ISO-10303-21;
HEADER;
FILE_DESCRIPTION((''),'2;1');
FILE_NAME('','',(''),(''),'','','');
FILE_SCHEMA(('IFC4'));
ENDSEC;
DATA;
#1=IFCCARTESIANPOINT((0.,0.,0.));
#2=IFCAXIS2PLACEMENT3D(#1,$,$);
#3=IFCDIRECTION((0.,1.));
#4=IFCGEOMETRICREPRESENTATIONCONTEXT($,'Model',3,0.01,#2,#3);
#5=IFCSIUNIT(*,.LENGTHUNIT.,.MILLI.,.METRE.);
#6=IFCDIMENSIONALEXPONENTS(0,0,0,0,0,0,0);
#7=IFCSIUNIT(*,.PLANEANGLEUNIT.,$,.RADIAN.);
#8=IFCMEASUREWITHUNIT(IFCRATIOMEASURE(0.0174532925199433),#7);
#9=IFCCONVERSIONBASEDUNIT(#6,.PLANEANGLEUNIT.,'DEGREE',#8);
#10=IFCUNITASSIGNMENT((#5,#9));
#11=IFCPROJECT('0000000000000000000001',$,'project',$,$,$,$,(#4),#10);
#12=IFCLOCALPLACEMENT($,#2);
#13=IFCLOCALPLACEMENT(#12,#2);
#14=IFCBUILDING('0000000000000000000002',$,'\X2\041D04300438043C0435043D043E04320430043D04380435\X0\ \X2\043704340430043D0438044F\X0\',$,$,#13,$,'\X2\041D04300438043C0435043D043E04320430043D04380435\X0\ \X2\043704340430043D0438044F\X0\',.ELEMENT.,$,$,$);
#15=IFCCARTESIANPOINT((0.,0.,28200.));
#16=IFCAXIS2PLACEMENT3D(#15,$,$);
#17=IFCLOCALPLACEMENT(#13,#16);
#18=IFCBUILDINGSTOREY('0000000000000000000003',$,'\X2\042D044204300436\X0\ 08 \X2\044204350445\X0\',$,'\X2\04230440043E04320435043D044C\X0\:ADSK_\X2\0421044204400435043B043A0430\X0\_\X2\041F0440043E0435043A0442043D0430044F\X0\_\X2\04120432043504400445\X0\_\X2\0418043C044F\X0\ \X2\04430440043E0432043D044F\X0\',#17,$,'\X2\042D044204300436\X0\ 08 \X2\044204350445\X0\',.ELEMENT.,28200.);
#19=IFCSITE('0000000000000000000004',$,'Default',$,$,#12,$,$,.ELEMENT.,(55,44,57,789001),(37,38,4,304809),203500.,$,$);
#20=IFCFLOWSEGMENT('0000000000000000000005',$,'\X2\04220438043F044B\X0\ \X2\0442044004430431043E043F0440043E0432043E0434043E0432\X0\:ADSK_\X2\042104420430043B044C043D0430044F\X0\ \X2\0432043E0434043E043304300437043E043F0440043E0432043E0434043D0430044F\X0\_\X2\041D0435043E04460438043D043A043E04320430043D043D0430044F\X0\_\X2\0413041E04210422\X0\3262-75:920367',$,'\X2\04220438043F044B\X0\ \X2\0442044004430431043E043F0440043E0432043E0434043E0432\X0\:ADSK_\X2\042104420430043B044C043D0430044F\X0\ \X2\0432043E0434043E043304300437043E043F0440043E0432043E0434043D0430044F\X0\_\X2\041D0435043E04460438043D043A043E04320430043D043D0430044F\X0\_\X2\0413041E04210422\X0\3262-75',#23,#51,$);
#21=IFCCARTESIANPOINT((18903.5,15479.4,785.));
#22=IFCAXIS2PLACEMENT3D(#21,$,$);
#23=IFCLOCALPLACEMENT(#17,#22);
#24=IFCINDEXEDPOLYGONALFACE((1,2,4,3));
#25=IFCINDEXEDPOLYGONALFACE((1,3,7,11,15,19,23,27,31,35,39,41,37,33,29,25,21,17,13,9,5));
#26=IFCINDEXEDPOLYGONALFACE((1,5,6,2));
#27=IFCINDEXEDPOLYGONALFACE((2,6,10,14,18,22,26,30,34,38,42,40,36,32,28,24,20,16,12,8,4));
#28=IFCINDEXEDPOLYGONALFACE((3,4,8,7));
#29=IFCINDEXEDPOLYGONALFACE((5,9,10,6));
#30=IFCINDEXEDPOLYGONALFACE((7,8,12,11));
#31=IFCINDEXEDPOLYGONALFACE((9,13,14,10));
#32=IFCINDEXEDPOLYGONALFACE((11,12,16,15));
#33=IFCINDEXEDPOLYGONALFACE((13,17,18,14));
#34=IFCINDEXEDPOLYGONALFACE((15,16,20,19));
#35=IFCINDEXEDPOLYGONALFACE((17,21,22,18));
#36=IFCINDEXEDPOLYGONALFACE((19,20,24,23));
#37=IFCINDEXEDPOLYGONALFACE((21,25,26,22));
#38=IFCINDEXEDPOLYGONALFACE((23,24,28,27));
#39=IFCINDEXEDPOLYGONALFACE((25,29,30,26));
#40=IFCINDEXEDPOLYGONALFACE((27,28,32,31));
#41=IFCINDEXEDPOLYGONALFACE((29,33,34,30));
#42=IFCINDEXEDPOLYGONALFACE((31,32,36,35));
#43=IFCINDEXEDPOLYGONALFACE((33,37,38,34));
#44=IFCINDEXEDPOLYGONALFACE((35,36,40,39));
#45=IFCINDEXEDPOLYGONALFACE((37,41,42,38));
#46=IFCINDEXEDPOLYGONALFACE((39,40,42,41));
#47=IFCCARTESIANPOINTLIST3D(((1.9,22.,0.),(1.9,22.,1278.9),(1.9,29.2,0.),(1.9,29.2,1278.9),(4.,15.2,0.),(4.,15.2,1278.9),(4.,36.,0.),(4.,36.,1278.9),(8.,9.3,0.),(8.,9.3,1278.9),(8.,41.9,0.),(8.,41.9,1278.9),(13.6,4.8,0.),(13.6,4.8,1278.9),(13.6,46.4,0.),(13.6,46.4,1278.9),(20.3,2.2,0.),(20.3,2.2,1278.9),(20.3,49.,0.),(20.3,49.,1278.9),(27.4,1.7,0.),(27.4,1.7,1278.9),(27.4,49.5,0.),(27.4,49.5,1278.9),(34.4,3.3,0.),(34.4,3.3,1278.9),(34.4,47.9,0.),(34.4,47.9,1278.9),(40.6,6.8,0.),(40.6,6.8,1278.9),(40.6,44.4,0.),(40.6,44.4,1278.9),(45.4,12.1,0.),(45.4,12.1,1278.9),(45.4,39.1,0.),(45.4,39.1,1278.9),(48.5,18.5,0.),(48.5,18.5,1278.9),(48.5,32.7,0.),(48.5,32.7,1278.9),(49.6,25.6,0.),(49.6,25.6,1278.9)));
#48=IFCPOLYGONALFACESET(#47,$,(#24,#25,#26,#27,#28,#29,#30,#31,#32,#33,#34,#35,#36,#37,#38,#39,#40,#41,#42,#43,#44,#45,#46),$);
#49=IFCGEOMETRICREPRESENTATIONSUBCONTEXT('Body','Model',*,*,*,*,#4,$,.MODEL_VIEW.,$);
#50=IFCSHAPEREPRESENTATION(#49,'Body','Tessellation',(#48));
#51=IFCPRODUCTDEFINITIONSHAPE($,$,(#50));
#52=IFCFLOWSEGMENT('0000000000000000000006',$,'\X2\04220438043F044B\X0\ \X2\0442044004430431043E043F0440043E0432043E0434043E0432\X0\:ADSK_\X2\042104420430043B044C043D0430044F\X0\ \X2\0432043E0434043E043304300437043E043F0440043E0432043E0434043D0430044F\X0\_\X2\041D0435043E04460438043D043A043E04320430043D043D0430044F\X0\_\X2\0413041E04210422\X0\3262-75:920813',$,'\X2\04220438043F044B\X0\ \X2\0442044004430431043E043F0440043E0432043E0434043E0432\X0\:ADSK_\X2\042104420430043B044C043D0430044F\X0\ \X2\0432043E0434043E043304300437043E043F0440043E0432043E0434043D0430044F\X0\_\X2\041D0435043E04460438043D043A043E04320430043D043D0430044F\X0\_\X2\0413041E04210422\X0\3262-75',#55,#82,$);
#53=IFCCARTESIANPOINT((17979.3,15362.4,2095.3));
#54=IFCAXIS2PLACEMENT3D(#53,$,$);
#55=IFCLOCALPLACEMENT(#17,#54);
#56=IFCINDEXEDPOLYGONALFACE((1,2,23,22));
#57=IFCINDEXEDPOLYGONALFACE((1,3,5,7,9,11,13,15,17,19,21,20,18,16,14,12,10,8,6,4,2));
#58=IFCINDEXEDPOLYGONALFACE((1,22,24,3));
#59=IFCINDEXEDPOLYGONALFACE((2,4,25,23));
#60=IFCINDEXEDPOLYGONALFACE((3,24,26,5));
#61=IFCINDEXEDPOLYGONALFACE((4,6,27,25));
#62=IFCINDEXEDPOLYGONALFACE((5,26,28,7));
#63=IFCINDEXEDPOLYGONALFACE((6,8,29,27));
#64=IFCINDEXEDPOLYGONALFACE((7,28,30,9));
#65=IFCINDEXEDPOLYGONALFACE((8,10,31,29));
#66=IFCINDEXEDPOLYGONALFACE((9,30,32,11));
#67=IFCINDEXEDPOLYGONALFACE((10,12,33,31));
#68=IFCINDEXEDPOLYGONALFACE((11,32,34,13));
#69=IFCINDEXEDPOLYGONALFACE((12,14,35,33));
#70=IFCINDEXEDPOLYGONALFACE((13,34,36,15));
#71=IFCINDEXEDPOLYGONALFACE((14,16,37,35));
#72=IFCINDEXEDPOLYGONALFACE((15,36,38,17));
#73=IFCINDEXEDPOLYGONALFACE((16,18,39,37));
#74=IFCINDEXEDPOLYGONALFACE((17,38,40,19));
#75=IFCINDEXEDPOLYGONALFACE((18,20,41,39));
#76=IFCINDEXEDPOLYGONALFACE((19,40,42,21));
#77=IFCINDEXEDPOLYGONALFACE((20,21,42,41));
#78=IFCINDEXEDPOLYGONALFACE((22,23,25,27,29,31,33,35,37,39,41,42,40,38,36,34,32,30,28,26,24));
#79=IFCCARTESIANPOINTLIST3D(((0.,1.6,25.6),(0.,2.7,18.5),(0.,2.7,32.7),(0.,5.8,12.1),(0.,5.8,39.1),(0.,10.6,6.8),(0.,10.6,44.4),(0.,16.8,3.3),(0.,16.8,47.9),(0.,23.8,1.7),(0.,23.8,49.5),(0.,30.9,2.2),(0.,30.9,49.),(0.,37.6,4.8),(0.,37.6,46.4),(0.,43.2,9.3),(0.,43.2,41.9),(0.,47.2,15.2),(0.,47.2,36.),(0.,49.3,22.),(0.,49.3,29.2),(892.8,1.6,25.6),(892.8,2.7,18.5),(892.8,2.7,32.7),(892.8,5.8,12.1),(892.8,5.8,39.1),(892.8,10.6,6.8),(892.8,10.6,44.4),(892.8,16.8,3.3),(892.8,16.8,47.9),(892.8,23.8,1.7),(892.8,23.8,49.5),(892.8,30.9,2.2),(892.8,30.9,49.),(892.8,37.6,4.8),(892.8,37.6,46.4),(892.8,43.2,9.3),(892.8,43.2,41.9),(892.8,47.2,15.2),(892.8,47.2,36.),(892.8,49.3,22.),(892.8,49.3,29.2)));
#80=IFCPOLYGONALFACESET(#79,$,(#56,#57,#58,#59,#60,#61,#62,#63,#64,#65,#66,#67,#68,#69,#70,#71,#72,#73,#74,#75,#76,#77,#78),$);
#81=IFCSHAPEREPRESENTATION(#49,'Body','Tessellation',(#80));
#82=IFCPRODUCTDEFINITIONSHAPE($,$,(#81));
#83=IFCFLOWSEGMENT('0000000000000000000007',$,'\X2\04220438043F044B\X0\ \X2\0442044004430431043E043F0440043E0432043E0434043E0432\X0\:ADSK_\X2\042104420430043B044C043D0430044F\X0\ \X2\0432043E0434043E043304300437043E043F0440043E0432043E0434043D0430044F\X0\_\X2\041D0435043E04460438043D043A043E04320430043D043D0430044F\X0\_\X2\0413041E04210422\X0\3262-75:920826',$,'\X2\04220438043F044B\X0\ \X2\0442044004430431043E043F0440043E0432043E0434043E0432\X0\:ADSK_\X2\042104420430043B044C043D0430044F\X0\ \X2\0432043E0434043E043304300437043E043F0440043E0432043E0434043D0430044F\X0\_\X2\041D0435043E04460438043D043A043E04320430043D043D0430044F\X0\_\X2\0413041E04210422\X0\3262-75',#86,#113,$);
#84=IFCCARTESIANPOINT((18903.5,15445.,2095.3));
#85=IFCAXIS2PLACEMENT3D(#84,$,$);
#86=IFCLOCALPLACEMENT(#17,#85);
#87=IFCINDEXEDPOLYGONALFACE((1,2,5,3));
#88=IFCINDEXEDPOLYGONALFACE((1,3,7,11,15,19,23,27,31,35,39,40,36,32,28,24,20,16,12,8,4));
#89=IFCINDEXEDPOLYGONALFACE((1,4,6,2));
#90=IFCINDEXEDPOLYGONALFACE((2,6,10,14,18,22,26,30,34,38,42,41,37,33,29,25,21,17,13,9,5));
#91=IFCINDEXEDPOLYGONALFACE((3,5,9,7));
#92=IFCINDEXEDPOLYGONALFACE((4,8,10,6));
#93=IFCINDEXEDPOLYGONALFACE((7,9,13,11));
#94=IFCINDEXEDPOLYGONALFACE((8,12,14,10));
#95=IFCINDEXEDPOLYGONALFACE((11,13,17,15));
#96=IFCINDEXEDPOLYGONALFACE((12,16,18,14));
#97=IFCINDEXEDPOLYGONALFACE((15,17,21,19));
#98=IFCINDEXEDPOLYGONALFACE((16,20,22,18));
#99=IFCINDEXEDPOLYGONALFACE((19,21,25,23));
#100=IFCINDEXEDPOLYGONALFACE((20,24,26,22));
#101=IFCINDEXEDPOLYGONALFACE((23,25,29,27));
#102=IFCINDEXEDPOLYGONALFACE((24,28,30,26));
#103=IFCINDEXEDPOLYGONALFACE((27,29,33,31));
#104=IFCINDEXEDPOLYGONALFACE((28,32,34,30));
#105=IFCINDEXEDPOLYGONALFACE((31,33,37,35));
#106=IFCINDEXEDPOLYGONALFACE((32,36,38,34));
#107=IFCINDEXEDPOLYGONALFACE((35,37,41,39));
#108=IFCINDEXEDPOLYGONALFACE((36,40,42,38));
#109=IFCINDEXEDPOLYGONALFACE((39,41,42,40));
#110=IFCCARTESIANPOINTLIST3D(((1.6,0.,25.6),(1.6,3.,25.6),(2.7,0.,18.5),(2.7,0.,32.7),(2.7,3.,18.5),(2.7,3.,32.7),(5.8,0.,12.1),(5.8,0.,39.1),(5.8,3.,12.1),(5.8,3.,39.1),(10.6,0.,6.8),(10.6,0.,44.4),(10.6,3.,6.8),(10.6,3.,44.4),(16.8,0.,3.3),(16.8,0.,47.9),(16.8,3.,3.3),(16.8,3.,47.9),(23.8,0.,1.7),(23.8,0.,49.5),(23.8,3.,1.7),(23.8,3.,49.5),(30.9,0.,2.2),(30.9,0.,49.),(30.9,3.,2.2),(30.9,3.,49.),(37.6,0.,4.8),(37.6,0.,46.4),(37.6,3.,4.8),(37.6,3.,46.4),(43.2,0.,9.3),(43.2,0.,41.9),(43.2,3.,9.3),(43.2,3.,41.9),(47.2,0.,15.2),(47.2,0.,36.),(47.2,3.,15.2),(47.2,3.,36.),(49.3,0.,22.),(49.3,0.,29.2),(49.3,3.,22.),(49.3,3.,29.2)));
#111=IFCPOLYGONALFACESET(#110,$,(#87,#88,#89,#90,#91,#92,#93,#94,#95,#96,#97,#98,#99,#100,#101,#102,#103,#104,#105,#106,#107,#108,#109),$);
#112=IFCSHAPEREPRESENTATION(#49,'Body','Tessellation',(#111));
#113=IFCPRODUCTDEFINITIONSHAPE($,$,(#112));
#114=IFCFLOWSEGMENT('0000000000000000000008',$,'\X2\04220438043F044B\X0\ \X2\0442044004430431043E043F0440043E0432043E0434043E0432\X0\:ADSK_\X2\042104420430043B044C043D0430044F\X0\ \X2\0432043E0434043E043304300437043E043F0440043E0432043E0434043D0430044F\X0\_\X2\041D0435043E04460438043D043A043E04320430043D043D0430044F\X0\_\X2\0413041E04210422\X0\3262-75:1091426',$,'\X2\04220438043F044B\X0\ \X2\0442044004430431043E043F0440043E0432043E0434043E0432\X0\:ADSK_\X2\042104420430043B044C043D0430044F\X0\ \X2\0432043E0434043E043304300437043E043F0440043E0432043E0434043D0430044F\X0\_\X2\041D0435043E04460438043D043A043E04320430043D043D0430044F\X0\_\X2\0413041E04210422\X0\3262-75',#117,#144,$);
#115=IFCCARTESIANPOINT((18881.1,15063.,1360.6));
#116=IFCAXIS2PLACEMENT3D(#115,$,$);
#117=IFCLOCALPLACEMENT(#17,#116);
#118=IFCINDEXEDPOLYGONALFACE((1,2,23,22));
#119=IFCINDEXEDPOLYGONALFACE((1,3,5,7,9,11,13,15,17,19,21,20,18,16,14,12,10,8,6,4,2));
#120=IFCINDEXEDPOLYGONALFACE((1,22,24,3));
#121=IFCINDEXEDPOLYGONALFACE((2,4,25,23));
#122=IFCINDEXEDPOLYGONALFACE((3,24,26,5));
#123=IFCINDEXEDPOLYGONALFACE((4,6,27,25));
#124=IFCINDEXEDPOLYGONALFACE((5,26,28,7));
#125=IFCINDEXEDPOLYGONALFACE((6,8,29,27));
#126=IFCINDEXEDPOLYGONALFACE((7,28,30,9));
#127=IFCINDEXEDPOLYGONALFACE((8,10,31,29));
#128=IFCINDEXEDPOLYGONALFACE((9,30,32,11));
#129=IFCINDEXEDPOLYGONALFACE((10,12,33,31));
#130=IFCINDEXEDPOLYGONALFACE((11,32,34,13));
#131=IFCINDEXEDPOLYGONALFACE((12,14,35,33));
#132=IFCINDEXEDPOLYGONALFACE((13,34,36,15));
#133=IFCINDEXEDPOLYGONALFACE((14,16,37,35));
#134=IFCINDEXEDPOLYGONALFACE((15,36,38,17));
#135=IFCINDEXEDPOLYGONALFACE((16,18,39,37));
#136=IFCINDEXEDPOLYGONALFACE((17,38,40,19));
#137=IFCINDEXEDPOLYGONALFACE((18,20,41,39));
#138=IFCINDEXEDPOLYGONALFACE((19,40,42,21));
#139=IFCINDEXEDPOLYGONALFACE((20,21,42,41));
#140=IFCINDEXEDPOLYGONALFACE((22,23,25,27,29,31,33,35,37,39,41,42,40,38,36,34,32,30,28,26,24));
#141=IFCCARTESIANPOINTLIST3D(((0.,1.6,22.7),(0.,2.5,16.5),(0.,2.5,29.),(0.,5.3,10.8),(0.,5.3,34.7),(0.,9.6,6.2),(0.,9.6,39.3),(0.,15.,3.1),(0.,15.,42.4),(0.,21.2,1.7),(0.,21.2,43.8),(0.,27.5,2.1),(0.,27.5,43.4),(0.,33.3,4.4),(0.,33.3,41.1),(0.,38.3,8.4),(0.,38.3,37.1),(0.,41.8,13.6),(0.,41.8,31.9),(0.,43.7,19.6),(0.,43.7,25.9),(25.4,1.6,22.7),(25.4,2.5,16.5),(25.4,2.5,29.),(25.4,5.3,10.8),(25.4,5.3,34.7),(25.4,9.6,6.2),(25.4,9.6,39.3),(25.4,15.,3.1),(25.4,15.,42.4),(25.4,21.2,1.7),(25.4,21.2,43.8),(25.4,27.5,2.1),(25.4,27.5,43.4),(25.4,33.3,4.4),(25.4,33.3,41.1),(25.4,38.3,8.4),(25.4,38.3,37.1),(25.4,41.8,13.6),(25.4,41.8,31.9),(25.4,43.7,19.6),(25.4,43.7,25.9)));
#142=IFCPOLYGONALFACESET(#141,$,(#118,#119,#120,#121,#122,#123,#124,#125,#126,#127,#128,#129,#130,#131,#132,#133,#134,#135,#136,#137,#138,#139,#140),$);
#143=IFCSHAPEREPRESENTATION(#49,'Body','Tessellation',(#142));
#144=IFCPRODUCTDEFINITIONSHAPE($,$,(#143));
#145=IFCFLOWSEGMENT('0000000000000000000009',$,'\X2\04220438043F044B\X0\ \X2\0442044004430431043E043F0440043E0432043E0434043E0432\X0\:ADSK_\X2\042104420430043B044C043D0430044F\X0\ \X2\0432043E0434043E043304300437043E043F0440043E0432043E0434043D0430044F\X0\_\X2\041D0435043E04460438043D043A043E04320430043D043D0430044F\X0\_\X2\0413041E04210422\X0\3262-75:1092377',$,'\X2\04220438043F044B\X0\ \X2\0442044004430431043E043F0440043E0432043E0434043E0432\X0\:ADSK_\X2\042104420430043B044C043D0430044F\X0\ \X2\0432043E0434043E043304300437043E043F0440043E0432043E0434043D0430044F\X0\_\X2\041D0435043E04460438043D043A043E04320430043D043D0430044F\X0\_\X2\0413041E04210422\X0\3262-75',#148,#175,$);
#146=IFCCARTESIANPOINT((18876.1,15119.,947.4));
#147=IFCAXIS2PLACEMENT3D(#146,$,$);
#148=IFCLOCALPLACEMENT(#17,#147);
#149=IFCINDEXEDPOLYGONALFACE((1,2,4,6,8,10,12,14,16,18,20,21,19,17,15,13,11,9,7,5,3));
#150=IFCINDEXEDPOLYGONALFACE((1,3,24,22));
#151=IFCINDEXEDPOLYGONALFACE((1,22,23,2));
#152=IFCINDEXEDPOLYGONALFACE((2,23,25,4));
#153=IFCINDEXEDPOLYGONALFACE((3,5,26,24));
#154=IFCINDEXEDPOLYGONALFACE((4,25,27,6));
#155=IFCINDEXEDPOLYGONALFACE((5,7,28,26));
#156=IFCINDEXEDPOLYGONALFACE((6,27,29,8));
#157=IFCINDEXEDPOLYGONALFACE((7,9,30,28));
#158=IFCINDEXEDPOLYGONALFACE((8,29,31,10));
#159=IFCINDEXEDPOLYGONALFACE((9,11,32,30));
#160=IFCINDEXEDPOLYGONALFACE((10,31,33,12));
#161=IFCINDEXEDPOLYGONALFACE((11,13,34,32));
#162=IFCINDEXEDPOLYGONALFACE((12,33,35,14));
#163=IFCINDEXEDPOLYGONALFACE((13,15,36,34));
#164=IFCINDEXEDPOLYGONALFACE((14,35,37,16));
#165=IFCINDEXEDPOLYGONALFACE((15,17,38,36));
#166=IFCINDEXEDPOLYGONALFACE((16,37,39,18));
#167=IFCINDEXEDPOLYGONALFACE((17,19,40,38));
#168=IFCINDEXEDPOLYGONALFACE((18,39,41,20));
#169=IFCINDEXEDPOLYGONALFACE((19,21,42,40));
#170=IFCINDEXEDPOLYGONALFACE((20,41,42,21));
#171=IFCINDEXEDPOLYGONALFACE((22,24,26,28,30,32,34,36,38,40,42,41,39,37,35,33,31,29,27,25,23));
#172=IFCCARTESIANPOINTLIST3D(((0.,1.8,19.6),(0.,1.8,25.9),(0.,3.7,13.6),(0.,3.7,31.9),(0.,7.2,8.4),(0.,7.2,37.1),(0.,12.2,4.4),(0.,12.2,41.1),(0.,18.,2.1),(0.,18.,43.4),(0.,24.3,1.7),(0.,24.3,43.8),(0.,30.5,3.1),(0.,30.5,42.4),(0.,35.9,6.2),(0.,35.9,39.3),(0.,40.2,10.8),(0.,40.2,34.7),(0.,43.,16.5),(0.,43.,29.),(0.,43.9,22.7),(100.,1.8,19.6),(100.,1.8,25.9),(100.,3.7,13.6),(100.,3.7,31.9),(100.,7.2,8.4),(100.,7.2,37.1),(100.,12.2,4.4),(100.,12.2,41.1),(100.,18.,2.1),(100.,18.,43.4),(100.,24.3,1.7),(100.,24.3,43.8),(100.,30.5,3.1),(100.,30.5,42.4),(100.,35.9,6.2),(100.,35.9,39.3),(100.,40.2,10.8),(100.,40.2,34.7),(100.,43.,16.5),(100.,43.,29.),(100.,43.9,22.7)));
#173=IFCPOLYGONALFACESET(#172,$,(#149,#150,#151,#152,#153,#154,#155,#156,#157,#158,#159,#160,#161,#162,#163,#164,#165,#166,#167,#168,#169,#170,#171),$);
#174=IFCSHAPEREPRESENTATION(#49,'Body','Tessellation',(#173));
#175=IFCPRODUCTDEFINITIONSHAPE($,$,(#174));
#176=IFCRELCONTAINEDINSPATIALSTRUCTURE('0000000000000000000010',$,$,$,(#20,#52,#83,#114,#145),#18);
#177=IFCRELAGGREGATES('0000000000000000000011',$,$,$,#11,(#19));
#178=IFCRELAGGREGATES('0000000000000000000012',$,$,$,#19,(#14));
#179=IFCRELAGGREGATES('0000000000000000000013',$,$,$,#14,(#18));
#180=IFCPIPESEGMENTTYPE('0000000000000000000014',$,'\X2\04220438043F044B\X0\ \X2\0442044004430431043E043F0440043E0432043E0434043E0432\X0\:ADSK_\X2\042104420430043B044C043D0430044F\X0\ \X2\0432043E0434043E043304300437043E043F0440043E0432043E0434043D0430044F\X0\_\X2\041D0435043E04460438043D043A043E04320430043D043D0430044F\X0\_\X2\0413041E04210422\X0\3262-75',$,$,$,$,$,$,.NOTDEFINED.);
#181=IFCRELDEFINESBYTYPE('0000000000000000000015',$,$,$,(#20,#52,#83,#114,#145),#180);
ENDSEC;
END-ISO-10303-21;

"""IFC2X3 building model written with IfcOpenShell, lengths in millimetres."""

from ifc_helpers import new_model, entity, si_unit, converted_unit, direction, frame, origin, origin_2d_with_axis, place, context, subcontext, project, spatial, circle, extrude, type_object, element, save


model = new_model("IFC2X3")

# Units and contexts
model_context = context("Model", 3, precision=0.01, world=origin(), true_north=direction((0.0, 1.0)))
body_context = subcontext(model_context, "Body", "Model", "MODEL_VIEW")
ifc_project = project(units=[si_unit("LENGTHUNIT", "METRE", prefix="MILLI"), converted_unit("PLANEANGLEUNIT", "DEGREE", entity("IfcRatioMeasure", 0.0174532925199433), si_unit("PLANEANGLEUNIT", "RADIAN"), dimensions=[0, 0, 0, 0, 0, 0, 0])], contexts=[model_context])

# Site, building, storey
site_placement = place(None, origin())
site = spatial("IfcSite", under=ifc_project, at=site_placement, Name="Default", CompositionType="ELEMENT", RefLatitude=(55, 44, 57, 789001), RefLongitude=(37, 38, 4, 304809), RefElevation=203500.0)
building_placement = place(site_placement, origin())
building = spatial("IfcBuilding", under=site, at=building_placement, Name="Наименование здания", LongName="Наименование здания", CompositionType="ELEMENT")
storey_placement = place(building_placement, frame((0.0, 0.0, 28200.0)))
storey = spatial("IfcBuildingStorey", under=building, at=storey_placement, Name="Этаж 08 тех", ObjectType="Уровень:ADSK_Стрелка_Проектная_Вверх_Имя уровня", LongName="Этаж 08 тех", CompositionType="ELEMENT", Elevation=28200.0)

# Flow segments
pipe_segment_type_1 = type_object("IfcPipeSegmentType", Name="Типы трубопроводов:ADSK_Стальная водогазопроводная_Неоцинкованная_ГОСТ3262-75", PredefinedType="NOTDEFINED")
flow_segment_1_placement = place(storey_placement, frame((18903.5, 15479.4, 785.0)))
element("IfcFlowSegment", 1, at=flow_segment_1_placement, inside=storey, type_object=pipe_segment_type_1, Name="Типы трубопроводов:ADSK_Стальная водогазопроводная_Неоцинкованная_ГОСТ3262-75:920367", ObjectType="Типы трубопроводов:ADSK_Стальная водогазопроводная_Неоцинкованная_ГОСТ3262-75", context=body_context, shape_type="SweptSolid", body=[
    extrude(circle(Radius=24.0, at=origin_2d_with_axis()), frame((25.6, 25.6, 0.0)), (0.0, 0.0, 1.0), 1278.9),
])
flow_segment_2_placement = place(storey_placement, frame((17979.3, 15362.4, 2095.3)))
element("IfcFlowSegment", 2, at=flow_segment_2_placement, inside=storey, type_object=pipe_segment_type_1, Name="Типы трубопроводов:ADSK_Стальная водогазопроводная_Неоцинкованная_ГОСТ3262-75:920813", ObjectType="Типы трубопроводов:ADSK_Стальная водогазопроводная_Неоцинкованная_ГОСТ3262-75", context=body_context, shape_type="SweptSolid", body=[
    extrude(circle(Radius=24.0, at=origin_2d_with_axis()), frame((0.0, 25.6, 25.6), z_axis=(1.0, 0.0, 0.0), x_axis=(0.0, -1.0, 0.0)), (0.0, 0.0, 1.0), 892.8),
])
flow_segment_3_placement = place(storey_placement, frame((18903.5, 15445.0, 2095.3)))
element("IfcFlowSegment", 3, at=flow_segment_3_placement, inside=storey, type_object=pipe_segment_type_1, Name="Типы трубопроводов:ADSK_Стальная водогазопроводная_Неоцинкованная_ГОСТ3262-75:920826", ObjectType="Типы трубопроводов:ADSK_Стальная водогазопроводная_Неоцинкованная_ГОСТ3262-75", context=body_context, shape_type="SweptSolid", body=[
    extrude(circle(Radius=24.0, at=origin_2d_with_axis()), frame((25.6, 0.0, 25.6), z_axis=(0.0, 1.0, 0.0), x_axis=(-1.0, 0.0, 0.0)), (0.0, 0.0, 1.0), 3.0),
])
flow_segment_4_placement = place(storey_placement, frame((18881.1, 15063.0, 1360.6)))
element("IfcFlowSegment", 4, at=flow_segment_4_placement, inside=storey, type_object=pipe_segment_type_1, Name="Типы трубопроводов:ADSK_Стальная водогазопроводная_Неоцинкованная_ГОСТ3262-75:1091426", ObjectType="Типы трубопроводов:ADSK_Стальная водогазопроводная_Неоцинкованная_ГОСТ3262-75", context=body_context, shape_type="SweptSolid", body=[
    extrude(circle(Radius=21.1, at=origin_2d_with_axis()), frame((0.0, 22.8, 22.8), z_axis=(1.0, 0.0, 0.0), x_axis=(0.0, -1.0, 0.0)), (0.0, 0.0, 1.0), 25.4),
])
flow_segment_5_placement = place(storey_placement, frame((18876.1, 15119.0, 947.4)))
element("IfcFlowSegment", 5, at=flow_segment_5_placement, inside=storey, type_object=pipe_segment_type_1, Name="Типы трубопроводов:ADSK_Стальная водогазопроводная_Неоцинкованная_ГОСТ3262-75:1092377", ObjectType="Типы трубопроводов:ADSK_Стальная водогазопроводная_Неоцинкованная_ГОСТ3262-75", context=body_context, shape_type="SweptSolid", body=[
    extrude(circle(Radius=21.1, at=origin_2d_with_axis()), frame((0.0, 22.8, 22.8), z_axis=(1.0, 0.0, 0.0), x_axis=(0.0, 1.0, 0.0)), (0.0, 0.0, 1.0), 100.0),
])

save(model, "model.ifc")
